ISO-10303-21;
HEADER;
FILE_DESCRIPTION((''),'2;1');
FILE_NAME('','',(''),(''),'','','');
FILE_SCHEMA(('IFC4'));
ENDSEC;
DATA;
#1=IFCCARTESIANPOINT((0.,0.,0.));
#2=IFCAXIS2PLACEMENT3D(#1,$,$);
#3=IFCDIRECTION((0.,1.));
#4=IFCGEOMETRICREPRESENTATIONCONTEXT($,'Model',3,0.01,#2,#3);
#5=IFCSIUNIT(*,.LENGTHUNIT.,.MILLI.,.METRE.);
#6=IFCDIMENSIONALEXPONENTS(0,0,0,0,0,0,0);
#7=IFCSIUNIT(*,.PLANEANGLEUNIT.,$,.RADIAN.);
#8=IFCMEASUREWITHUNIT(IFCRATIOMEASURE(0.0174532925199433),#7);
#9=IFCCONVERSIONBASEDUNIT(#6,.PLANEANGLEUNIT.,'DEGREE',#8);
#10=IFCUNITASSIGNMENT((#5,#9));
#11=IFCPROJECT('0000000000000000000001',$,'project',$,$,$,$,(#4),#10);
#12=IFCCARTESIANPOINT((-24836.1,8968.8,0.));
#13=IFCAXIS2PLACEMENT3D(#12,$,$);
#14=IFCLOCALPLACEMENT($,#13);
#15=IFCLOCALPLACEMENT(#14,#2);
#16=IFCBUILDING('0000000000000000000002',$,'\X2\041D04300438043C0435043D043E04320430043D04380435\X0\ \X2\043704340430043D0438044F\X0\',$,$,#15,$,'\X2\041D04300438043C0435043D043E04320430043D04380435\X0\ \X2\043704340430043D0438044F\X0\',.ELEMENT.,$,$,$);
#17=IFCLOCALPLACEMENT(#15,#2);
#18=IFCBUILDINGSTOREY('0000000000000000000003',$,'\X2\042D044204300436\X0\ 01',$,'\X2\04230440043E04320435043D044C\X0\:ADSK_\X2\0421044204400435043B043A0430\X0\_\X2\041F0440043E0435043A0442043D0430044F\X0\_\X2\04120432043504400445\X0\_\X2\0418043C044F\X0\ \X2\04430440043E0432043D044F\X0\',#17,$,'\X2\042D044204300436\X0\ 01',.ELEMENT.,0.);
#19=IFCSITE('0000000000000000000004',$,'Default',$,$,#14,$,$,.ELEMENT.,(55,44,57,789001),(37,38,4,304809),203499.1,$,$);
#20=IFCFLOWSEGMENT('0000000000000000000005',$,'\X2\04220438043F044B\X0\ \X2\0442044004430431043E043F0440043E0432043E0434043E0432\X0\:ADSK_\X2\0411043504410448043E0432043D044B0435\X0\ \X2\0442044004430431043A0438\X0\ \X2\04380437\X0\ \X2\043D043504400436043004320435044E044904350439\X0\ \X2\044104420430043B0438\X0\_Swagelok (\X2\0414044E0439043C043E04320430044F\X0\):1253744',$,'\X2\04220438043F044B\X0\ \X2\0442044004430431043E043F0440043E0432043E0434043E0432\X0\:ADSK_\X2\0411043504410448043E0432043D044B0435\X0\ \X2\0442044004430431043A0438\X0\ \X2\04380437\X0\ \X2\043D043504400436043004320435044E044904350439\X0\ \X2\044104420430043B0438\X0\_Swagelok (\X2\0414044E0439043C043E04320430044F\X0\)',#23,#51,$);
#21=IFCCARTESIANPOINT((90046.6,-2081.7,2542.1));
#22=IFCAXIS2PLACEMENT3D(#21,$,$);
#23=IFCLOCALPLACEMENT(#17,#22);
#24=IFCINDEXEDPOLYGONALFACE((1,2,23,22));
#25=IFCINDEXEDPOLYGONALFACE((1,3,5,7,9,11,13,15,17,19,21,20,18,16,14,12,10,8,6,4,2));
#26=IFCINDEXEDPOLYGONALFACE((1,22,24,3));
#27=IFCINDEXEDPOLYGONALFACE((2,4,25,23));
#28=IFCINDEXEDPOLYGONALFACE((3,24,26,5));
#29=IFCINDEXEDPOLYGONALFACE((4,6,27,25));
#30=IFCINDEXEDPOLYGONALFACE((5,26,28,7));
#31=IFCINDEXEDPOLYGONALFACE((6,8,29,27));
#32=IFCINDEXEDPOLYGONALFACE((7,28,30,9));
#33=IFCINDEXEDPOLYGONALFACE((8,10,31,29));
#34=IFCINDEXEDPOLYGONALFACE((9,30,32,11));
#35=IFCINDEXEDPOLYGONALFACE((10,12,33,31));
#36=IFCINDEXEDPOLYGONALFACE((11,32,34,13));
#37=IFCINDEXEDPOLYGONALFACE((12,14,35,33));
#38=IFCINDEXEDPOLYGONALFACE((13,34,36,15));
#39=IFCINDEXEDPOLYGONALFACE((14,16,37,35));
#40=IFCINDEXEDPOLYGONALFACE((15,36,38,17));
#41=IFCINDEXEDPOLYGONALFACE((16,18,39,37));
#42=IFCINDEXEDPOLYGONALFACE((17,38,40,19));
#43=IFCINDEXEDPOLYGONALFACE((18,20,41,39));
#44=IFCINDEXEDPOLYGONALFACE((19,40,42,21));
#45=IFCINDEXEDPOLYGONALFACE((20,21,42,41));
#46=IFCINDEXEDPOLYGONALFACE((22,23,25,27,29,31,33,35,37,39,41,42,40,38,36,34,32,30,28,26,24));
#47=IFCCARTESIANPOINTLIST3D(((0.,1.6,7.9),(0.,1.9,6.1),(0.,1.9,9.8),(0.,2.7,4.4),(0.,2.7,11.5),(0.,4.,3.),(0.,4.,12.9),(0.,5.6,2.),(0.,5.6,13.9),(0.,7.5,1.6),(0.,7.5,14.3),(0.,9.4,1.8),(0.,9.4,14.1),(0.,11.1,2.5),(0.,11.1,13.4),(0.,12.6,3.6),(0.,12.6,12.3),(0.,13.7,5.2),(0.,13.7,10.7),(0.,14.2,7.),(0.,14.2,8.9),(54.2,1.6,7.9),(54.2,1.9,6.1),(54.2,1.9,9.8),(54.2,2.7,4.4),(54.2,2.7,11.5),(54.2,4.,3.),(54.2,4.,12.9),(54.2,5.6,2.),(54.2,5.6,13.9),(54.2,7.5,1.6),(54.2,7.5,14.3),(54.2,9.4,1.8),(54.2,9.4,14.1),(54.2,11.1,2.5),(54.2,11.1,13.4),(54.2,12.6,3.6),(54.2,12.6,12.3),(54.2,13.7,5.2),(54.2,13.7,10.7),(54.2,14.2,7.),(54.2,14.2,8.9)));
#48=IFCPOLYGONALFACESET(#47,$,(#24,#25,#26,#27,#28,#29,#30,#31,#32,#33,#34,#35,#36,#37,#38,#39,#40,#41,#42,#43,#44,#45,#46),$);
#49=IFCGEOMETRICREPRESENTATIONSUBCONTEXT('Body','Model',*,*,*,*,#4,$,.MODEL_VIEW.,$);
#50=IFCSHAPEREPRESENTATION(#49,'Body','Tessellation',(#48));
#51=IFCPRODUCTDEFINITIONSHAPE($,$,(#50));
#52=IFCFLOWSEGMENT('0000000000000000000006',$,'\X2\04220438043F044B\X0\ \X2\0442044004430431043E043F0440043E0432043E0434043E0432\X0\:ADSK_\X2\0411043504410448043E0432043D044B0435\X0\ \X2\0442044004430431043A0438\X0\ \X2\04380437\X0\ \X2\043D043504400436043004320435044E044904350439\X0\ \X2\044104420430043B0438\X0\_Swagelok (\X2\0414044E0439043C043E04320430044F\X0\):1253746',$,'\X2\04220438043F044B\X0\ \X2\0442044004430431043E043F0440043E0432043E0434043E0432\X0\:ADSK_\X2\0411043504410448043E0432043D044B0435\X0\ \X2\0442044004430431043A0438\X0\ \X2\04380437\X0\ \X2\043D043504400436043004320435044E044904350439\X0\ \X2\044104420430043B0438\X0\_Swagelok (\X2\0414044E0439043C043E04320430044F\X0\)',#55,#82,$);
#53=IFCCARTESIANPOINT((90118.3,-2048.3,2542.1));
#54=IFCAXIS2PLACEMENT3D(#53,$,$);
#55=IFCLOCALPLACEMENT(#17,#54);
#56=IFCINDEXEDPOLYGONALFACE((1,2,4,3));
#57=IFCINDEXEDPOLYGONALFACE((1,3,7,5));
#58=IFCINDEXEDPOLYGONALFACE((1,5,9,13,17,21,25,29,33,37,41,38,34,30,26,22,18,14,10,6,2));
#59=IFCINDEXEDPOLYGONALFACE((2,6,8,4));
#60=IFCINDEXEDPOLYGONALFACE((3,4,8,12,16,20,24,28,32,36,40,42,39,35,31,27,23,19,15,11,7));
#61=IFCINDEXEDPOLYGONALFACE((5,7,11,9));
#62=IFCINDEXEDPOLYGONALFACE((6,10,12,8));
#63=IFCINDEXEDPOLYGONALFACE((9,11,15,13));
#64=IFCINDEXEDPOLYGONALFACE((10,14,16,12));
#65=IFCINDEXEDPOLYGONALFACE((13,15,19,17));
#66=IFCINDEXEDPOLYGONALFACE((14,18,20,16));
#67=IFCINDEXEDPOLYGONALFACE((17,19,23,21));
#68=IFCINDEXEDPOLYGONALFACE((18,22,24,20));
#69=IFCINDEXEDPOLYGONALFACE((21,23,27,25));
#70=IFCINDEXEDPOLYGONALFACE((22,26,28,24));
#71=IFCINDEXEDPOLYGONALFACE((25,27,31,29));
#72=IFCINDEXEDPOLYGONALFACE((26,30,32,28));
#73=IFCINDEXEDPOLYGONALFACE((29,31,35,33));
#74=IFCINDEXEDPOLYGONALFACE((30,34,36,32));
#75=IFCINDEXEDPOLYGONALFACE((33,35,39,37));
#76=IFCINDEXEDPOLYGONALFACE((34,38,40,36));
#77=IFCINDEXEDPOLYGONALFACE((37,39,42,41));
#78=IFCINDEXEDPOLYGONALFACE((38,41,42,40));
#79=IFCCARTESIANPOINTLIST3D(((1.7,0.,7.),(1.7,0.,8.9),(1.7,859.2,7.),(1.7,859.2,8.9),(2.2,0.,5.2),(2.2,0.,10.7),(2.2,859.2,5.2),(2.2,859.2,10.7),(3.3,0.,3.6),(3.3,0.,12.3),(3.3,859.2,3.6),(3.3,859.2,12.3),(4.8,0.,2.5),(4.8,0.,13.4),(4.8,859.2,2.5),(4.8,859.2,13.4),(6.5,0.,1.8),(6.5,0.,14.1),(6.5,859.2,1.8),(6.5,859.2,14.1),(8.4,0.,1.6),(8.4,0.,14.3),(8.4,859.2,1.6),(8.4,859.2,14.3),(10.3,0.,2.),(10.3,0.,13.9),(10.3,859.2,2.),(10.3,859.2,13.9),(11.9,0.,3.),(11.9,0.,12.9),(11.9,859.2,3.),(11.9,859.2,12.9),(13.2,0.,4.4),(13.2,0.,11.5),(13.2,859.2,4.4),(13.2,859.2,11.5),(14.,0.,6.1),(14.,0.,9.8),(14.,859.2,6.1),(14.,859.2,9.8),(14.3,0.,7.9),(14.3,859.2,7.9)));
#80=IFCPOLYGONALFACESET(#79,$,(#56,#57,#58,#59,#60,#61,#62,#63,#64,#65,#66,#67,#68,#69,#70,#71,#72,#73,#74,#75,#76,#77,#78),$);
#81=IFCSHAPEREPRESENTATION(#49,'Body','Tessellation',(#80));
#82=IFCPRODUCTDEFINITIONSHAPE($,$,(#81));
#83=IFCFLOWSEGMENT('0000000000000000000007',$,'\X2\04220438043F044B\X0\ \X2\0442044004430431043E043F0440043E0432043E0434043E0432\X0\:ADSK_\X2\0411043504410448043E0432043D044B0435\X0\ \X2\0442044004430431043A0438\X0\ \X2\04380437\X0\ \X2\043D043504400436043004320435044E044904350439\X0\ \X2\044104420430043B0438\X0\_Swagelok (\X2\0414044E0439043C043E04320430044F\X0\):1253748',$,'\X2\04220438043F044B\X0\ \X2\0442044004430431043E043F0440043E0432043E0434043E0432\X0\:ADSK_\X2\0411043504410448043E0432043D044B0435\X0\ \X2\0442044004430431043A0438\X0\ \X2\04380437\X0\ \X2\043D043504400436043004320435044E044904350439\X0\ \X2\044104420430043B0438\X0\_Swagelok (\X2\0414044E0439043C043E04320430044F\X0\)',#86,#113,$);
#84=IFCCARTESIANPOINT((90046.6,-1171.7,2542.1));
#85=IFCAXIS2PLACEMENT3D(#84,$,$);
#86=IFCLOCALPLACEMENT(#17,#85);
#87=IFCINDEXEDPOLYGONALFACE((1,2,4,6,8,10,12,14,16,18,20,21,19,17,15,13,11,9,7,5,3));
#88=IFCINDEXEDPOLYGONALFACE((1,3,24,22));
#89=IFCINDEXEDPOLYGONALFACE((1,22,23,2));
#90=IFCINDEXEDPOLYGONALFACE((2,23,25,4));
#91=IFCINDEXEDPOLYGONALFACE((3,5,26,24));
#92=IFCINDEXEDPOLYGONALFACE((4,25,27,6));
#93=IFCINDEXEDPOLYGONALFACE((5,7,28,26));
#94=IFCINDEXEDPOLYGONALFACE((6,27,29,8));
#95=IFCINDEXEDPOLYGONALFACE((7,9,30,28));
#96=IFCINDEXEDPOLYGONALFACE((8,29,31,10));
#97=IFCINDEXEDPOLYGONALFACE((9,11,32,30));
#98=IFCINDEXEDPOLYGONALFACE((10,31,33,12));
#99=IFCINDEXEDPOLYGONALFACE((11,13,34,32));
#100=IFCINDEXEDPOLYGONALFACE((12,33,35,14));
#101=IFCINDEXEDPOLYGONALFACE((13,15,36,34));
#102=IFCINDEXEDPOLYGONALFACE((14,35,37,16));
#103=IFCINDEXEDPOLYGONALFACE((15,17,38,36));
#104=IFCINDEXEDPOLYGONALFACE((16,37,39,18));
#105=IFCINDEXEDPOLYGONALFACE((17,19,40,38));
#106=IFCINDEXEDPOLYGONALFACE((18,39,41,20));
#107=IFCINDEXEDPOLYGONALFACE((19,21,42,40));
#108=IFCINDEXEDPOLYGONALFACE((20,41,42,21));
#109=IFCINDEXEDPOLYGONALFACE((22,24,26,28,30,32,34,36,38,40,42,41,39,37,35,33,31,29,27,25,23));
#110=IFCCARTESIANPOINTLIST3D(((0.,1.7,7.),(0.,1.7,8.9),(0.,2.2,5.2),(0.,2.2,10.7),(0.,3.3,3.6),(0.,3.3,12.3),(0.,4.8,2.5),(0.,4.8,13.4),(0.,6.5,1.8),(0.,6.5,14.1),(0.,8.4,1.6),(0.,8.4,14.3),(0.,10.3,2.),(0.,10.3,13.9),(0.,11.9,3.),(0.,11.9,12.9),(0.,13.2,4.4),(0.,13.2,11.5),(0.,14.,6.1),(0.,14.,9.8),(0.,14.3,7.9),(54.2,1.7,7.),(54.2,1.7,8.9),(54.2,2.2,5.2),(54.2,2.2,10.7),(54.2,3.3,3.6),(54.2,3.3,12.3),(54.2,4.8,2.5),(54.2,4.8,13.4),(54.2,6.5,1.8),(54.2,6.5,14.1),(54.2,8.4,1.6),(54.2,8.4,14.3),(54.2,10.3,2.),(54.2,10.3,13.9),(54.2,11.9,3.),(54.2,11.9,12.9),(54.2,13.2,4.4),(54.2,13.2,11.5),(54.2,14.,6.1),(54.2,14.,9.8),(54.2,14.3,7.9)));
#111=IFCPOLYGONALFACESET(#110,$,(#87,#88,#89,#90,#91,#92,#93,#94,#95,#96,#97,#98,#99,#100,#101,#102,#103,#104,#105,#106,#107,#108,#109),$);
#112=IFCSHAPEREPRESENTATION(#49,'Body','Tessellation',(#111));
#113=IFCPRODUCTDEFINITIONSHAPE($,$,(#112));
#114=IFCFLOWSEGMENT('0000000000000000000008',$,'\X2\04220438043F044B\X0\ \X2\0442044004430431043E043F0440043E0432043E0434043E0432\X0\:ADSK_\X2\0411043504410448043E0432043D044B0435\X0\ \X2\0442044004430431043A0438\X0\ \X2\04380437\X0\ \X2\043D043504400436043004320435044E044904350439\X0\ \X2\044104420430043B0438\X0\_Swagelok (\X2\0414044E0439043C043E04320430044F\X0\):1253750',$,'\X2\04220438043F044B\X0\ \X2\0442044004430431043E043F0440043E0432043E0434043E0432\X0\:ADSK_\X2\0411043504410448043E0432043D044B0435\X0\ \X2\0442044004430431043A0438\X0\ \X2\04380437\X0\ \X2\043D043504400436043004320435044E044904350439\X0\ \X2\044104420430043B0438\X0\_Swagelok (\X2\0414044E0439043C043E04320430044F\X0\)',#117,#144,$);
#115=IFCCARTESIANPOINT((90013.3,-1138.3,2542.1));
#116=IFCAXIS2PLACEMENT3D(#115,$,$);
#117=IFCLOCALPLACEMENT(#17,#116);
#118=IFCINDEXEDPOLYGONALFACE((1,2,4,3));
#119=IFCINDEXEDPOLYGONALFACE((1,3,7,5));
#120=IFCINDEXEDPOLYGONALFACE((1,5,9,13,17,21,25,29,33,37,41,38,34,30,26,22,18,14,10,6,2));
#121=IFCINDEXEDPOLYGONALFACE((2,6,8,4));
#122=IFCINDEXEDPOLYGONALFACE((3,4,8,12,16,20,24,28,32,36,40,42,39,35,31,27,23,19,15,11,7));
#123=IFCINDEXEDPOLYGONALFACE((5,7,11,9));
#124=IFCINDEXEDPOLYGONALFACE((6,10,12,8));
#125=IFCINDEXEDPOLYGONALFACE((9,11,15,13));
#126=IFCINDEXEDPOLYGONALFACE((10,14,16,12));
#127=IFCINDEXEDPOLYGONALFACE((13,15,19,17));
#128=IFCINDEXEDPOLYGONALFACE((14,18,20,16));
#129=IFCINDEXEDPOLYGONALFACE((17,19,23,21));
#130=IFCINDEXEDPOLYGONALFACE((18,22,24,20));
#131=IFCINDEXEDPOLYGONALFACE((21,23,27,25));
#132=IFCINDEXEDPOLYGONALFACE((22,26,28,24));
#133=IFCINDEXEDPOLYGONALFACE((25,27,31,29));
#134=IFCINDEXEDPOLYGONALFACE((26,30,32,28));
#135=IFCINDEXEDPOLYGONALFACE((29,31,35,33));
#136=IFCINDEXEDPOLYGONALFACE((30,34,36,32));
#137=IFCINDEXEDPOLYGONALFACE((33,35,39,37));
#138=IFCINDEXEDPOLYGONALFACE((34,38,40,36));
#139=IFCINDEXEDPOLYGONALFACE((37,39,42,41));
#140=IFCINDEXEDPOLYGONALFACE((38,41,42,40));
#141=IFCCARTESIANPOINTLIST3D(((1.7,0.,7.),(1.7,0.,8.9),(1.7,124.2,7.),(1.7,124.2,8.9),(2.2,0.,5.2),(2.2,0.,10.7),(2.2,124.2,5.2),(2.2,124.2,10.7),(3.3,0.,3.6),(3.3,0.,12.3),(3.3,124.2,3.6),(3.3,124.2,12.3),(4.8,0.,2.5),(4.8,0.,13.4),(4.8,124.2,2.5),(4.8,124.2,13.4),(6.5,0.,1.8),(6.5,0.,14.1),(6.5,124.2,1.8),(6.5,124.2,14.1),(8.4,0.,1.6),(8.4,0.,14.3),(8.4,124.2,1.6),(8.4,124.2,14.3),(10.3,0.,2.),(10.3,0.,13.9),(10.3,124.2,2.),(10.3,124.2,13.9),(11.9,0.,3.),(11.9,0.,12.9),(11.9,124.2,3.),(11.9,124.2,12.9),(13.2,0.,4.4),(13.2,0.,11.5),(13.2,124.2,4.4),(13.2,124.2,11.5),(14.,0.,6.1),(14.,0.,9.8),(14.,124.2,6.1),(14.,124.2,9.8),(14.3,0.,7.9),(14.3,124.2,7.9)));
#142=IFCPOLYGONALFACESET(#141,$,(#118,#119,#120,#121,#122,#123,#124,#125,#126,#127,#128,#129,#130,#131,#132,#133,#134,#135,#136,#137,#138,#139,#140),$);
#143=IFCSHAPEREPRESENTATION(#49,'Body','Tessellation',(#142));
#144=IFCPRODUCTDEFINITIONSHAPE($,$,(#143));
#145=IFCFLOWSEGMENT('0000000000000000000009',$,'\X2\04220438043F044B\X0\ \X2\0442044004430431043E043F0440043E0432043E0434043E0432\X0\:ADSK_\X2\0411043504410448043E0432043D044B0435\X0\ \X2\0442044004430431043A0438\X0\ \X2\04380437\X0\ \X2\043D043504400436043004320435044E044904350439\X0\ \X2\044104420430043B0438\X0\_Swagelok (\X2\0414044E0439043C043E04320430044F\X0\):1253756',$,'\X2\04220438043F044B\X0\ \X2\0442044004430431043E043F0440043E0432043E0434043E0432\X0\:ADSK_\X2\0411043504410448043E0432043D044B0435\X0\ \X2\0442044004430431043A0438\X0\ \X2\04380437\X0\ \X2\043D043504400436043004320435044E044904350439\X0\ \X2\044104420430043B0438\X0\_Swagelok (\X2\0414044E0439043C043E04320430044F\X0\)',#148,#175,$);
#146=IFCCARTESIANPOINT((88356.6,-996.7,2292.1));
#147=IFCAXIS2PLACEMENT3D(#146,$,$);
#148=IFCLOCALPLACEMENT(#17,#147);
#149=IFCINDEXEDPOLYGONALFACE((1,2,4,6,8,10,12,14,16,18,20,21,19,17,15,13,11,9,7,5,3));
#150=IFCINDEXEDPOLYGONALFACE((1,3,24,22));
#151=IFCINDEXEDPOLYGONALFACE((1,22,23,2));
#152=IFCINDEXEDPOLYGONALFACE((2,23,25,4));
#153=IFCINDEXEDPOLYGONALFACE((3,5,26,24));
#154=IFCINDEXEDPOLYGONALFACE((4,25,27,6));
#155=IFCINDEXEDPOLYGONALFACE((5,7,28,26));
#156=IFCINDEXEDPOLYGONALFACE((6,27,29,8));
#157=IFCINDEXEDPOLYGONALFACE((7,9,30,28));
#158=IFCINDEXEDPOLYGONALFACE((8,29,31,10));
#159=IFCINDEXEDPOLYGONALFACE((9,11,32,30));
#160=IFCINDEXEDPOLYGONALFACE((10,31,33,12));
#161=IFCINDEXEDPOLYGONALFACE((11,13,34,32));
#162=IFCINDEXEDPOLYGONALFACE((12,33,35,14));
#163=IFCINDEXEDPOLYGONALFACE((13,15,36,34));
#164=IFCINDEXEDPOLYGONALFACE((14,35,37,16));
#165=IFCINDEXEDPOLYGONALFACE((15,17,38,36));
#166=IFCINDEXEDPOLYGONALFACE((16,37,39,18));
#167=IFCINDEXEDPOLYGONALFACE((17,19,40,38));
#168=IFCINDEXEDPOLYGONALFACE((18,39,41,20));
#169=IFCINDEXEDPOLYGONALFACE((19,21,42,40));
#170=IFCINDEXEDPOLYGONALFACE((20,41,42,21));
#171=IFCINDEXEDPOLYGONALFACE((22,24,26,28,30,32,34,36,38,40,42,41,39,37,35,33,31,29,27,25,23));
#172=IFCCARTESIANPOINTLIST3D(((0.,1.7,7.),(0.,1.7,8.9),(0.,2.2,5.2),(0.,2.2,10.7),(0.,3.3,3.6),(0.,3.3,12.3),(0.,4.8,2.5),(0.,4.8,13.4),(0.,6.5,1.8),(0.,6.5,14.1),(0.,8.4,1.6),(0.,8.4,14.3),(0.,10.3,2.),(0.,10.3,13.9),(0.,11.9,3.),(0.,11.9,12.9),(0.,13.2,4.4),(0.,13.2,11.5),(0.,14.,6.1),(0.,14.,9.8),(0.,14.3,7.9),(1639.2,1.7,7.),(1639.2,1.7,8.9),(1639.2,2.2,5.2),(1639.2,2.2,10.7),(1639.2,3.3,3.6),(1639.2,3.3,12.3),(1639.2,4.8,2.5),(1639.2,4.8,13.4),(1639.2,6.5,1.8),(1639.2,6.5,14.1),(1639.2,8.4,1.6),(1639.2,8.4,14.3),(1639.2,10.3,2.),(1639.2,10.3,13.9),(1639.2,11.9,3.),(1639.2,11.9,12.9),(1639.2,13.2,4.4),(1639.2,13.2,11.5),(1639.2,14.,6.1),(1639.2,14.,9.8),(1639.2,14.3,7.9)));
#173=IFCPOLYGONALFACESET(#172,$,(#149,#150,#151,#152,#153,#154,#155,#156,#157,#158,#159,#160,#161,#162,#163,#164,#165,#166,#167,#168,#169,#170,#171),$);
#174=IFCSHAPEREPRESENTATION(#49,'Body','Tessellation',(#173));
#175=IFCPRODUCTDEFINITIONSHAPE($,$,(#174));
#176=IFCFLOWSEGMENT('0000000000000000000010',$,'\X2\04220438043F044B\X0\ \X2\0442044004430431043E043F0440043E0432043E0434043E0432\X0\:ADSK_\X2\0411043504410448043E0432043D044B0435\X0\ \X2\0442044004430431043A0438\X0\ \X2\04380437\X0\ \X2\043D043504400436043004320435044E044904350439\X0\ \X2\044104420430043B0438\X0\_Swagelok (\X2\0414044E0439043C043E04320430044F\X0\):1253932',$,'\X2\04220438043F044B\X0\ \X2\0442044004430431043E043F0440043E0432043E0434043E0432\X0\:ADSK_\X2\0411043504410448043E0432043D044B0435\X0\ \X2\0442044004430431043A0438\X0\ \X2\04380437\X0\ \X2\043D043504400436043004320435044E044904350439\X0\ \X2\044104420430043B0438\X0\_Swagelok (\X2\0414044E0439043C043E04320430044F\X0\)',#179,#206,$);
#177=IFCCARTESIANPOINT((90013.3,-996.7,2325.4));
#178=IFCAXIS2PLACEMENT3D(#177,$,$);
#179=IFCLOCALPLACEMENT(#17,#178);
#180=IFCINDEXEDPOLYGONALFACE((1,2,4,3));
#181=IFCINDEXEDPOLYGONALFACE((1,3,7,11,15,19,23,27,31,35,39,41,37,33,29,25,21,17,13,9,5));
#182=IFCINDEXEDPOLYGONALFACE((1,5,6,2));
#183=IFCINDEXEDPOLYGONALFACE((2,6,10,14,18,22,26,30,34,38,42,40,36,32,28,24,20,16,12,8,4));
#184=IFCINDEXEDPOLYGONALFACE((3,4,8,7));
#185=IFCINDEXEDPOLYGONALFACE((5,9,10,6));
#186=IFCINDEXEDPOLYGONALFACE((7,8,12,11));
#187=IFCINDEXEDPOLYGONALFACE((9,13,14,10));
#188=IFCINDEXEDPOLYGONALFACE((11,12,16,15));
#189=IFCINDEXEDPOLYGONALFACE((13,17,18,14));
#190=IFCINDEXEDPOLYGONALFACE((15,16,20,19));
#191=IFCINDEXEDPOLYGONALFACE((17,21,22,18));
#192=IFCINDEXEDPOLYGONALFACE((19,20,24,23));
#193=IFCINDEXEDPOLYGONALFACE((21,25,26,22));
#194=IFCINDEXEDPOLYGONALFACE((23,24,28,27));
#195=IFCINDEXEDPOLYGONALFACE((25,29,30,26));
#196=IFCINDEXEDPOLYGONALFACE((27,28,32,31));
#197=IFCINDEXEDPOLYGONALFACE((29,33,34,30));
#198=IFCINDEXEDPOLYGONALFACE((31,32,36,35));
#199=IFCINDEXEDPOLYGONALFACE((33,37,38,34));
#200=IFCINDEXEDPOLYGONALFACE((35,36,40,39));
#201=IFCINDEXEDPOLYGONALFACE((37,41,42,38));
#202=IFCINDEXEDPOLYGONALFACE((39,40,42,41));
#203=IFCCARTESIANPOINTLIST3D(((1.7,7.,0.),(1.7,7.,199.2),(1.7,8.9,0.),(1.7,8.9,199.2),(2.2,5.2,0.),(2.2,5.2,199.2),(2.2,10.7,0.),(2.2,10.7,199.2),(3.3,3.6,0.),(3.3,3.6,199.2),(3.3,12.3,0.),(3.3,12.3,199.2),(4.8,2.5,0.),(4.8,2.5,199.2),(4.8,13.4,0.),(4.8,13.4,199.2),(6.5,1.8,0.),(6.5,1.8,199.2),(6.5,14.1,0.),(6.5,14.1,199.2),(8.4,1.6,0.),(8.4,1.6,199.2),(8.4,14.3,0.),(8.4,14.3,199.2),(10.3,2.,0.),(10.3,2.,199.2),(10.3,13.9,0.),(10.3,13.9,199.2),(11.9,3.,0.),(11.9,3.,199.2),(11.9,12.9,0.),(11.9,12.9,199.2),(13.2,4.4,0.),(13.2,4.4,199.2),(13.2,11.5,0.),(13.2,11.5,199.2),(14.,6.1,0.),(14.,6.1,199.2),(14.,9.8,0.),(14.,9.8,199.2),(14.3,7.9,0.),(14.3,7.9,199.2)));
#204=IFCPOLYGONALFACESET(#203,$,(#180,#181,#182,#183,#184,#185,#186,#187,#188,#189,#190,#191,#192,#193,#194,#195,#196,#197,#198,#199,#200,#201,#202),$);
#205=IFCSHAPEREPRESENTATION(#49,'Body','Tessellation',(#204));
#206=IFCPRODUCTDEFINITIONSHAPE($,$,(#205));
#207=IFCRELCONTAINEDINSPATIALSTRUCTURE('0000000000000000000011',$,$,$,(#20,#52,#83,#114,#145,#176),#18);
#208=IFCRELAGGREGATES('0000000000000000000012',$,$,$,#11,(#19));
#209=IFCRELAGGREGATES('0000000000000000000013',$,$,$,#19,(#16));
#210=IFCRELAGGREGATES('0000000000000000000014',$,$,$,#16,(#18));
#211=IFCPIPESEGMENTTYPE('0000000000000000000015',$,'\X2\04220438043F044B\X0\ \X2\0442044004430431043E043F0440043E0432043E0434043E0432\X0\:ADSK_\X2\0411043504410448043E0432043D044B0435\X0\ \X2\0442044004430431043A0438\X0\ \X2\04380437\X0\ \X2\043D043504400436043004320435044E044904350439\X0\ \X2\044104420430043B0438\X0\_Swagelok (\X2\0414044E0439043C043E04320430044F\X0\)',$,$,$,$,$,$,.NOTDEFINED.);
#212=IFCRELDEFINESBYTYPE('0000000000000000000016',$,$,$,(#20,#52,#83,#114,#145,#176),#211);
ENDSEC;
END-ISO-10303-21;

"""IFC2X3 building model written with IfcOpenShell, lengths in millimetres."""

from ifc_helpers import new_model, entity, si_unit, converted_unit, direction, frame, origin, origin_2d_with_axis, place, context, subcontext, project, spatial, circle, extrude, type_object, element, save


model = new_model("IFC2X3")

# Units and contexts
model_context = context("Model", 3, precision=0.01, world=origin(), true_north=direction((0.0, 1.0)))
body_context = subcontext(model_context, "Body", "Model", "MODEL_VIEW")
ifc_project = project(units=[si_unit("LENGTHUNIT", "METRE", prefix="MILLI"), converted_unit("PLANEANGLEUNIT", "DEGREE", entity("IfcRatioMeasure", 0.0174532925199433), si_unit("PLANEANGLEUNIT", "RADIAN"), dimensions=[0, 0, 0, 0, 0, 0, 0])], contexts=[model_context])

# Site, building, storey
site_placement = place(None, frame((-24836.1, 8968.8, 0.0)))
site = spatial("IfcSite", under=ifc_project, at=site_placement, Name="Default", CompositionType="ELEMENT", RefLatitude=(55, 44, 57, 789001), RefLongitude=(37, 38, 4, 304809), RefElevation=203499.1)
building_placement = place(site_placement, origin())
building = spatial("IfcBuilding", under=site, at=building_placement, Name="Наименование здания", LongName="Наименование здания", CompositionType="ELEMENT")
storey_placement = place(building_placement, origin())
storey = spatial("IfcBuildingStorey", under=building, at=storey_placement, Name="Этаж 01", ObjectType="Уровень:ADSK_Стрелка_Проектная_Вверх_Имя уровня", LongName="Этаж 01", CompositionType="ELEMENT", Elevation=0.0)

# Flow segments
pipe_segment_type_1 = type_object("IfcPipeSegmentType", Name="Типы трубопроводов:ADSK_Бесшовные трубки из нержавеющей стали_Swagelok (Дюймовая)", PredefinedType="NOTDEFINED")
flow_segment_1_placement = place(storey_placement, frame((90046.6, -2081.7, 2542.1)))
element("IfcFlowSegment", 1, at=flow_segment_1_placement, inside=storey, type_object=pipe_segment_type_1, Name="Типы трубопроводов:ADSK_Бесшовные трубки из нержавеющей стали_Swagelok (Дюймовая):1253744", ObjectType="Типы трубопроводов:ADSK_Бесшовные трубки из нержавеющей стали_Swagelok (Дюймовая)", context=body_context, shape_type="SweptSolid", body=[
    extrude(circle(Radius=6.3, at=origin_2d_with_axis()), frame((0.0, 8.0, 8.0), z_axis=(1.0, 0.0, 0.0), x_axis=(0.0, -1.0, 0.0)), (0.0, 0.0, 1.0), 54.2),
])
flow_segment_2_placement = place(storey_placement, frame((90118.3, -2048.3, 2542.1)))
element("IfcFlowSegment", 2, at=flow_segment_2_placement, inside=storey, type_object=pipe_segment_type_1, Name="Типы трубопроводов:ADSK_Бесшовные трубки из нержавеющей стали_Swagelok (Дюймовая):1253746", ObjectType="Типы трубопроводов:ADSK_Бесшовные трубки из нержавеющей стали_Swagelok (Дюймовая)", context=body_context, shape_type="SweptSolid", body=[
    extrude(circle(Radius=6.3, at=origin_2d_with_axis()), frame((8.0, 0.0, 8.0), z_axis=(0.0, 1.0, 0.0), x_axis=(1.0, 0.0, 0.0)), (0.0, 0.0, 1.0), 859.2),
])
flow_segment_3_placement = place(storey_placement, frame((90046.6, -1171.7, 2542.1)))
element("IfcFlowSegment", 3, at=flow_segment_3_placement, inside=storey, type_object=pipe_segment_type_1, Name="Типы трубопроводов:ADSK_Бесшовные трубки из нержавеющей стали_Swagelok (Дюймовая):1253748", ObjectType="Типы трубопроводов:ADSK_Бесшовные трубки из нержавеющей стали_Swagelok (Дюймовая)", context=body_context, shape_type="SweptSolid", body=[
    extrude(circle(Radius=6.3, at=origin_2d_with_axis()), frame((0.0, 8.0, 8.0), z_axis=(1.0, 0.0, 0.0), x_axis=(0.0, 1.0, 0.0)), (0.0, 0.0, 1.0), 54.2),
])
flow_segment_4_placement = place(storey_placement, frame((90013.3, -1138.3, 2542.1)))
element("IfcFlowSegment", 4, at=flow_segment_4_placement, inside=storey, type_object=pipe_segment_type_1, Name="Типы трубопроводов:ADSK_Бесшовные трубки из нержавеющей стали_Swagelok (Дюймовая):1253750", ObjectType="Типы трубопроводов:ADSK_Бесшовные трубки из нержавеющей стали_Swagelok (Дюймовая)", context=body_context, shape_type="SweptSolid", body=[
    extrude(circle(Radius=6.3, at=origin_2d_with_axis()), frame((8.0, 0.0, 8.0), z_axis=(0.0, 1.0, 0.0), x_axis=(1.0, 0.0, 0.0)), (0.0, 0.0, 1.0), 124.2),
])
flow_segment_5_placement = place(storey_placement, frame((88356.6, -996.7, 2292.1)))
element("IfcFlowSegment", 5, at=flow_segment_5_placement, inside=storey, type_object=pipe_segment_type_1, Name="Типы трубопроводов:ADSK_Бесшовные трубки из нержавеющей стали_Swagelok (Дюймовая):1253756", ObjectType="Типы трубопроводов:ADSK_Бесшовные трубки из нержавеющей стали_Swagelok (Дюймовая)", context=body_context, shape_type="SweptSolid", body=[
    extrude(circle(Radius=6.3, at=origin_2d_with_axis()), frame((0.0, 8.0, 8.0), z_axis=(1.0, 0.0, 0.0), x_axis=(0.0, 1.0, 0.0)), (0.0, 0.0, 1.0), 1639.2),
])
flow_segment_6_placement = place(storey_placement, frame((90013.3, -996.7, 2325.4)))
element("IfcFlowSegment", 6, at=flow_segment_6_placement, inside=storey, type_object=pipe_segment_type_1, Name="Типы трубопроводов:ADSK_Бесшовные трубки из нержавеющей стали_Swagelok (Дюймовая):1253932", ObjectType="Типы трубопроводов:ADSK_Бесшовные трубки из нержавеющей стали_Swagelok (Дюймовая)", context=body_context, shape_type="SweptSolid", body=[
    extrude(circle(Radius=6.3, at=origin_2d_with_axis()), frame((8.0, 8.0, 0.0)), (0.0, 0.0, 1.0), 199.2),
])

save(model, "model.ifc")
